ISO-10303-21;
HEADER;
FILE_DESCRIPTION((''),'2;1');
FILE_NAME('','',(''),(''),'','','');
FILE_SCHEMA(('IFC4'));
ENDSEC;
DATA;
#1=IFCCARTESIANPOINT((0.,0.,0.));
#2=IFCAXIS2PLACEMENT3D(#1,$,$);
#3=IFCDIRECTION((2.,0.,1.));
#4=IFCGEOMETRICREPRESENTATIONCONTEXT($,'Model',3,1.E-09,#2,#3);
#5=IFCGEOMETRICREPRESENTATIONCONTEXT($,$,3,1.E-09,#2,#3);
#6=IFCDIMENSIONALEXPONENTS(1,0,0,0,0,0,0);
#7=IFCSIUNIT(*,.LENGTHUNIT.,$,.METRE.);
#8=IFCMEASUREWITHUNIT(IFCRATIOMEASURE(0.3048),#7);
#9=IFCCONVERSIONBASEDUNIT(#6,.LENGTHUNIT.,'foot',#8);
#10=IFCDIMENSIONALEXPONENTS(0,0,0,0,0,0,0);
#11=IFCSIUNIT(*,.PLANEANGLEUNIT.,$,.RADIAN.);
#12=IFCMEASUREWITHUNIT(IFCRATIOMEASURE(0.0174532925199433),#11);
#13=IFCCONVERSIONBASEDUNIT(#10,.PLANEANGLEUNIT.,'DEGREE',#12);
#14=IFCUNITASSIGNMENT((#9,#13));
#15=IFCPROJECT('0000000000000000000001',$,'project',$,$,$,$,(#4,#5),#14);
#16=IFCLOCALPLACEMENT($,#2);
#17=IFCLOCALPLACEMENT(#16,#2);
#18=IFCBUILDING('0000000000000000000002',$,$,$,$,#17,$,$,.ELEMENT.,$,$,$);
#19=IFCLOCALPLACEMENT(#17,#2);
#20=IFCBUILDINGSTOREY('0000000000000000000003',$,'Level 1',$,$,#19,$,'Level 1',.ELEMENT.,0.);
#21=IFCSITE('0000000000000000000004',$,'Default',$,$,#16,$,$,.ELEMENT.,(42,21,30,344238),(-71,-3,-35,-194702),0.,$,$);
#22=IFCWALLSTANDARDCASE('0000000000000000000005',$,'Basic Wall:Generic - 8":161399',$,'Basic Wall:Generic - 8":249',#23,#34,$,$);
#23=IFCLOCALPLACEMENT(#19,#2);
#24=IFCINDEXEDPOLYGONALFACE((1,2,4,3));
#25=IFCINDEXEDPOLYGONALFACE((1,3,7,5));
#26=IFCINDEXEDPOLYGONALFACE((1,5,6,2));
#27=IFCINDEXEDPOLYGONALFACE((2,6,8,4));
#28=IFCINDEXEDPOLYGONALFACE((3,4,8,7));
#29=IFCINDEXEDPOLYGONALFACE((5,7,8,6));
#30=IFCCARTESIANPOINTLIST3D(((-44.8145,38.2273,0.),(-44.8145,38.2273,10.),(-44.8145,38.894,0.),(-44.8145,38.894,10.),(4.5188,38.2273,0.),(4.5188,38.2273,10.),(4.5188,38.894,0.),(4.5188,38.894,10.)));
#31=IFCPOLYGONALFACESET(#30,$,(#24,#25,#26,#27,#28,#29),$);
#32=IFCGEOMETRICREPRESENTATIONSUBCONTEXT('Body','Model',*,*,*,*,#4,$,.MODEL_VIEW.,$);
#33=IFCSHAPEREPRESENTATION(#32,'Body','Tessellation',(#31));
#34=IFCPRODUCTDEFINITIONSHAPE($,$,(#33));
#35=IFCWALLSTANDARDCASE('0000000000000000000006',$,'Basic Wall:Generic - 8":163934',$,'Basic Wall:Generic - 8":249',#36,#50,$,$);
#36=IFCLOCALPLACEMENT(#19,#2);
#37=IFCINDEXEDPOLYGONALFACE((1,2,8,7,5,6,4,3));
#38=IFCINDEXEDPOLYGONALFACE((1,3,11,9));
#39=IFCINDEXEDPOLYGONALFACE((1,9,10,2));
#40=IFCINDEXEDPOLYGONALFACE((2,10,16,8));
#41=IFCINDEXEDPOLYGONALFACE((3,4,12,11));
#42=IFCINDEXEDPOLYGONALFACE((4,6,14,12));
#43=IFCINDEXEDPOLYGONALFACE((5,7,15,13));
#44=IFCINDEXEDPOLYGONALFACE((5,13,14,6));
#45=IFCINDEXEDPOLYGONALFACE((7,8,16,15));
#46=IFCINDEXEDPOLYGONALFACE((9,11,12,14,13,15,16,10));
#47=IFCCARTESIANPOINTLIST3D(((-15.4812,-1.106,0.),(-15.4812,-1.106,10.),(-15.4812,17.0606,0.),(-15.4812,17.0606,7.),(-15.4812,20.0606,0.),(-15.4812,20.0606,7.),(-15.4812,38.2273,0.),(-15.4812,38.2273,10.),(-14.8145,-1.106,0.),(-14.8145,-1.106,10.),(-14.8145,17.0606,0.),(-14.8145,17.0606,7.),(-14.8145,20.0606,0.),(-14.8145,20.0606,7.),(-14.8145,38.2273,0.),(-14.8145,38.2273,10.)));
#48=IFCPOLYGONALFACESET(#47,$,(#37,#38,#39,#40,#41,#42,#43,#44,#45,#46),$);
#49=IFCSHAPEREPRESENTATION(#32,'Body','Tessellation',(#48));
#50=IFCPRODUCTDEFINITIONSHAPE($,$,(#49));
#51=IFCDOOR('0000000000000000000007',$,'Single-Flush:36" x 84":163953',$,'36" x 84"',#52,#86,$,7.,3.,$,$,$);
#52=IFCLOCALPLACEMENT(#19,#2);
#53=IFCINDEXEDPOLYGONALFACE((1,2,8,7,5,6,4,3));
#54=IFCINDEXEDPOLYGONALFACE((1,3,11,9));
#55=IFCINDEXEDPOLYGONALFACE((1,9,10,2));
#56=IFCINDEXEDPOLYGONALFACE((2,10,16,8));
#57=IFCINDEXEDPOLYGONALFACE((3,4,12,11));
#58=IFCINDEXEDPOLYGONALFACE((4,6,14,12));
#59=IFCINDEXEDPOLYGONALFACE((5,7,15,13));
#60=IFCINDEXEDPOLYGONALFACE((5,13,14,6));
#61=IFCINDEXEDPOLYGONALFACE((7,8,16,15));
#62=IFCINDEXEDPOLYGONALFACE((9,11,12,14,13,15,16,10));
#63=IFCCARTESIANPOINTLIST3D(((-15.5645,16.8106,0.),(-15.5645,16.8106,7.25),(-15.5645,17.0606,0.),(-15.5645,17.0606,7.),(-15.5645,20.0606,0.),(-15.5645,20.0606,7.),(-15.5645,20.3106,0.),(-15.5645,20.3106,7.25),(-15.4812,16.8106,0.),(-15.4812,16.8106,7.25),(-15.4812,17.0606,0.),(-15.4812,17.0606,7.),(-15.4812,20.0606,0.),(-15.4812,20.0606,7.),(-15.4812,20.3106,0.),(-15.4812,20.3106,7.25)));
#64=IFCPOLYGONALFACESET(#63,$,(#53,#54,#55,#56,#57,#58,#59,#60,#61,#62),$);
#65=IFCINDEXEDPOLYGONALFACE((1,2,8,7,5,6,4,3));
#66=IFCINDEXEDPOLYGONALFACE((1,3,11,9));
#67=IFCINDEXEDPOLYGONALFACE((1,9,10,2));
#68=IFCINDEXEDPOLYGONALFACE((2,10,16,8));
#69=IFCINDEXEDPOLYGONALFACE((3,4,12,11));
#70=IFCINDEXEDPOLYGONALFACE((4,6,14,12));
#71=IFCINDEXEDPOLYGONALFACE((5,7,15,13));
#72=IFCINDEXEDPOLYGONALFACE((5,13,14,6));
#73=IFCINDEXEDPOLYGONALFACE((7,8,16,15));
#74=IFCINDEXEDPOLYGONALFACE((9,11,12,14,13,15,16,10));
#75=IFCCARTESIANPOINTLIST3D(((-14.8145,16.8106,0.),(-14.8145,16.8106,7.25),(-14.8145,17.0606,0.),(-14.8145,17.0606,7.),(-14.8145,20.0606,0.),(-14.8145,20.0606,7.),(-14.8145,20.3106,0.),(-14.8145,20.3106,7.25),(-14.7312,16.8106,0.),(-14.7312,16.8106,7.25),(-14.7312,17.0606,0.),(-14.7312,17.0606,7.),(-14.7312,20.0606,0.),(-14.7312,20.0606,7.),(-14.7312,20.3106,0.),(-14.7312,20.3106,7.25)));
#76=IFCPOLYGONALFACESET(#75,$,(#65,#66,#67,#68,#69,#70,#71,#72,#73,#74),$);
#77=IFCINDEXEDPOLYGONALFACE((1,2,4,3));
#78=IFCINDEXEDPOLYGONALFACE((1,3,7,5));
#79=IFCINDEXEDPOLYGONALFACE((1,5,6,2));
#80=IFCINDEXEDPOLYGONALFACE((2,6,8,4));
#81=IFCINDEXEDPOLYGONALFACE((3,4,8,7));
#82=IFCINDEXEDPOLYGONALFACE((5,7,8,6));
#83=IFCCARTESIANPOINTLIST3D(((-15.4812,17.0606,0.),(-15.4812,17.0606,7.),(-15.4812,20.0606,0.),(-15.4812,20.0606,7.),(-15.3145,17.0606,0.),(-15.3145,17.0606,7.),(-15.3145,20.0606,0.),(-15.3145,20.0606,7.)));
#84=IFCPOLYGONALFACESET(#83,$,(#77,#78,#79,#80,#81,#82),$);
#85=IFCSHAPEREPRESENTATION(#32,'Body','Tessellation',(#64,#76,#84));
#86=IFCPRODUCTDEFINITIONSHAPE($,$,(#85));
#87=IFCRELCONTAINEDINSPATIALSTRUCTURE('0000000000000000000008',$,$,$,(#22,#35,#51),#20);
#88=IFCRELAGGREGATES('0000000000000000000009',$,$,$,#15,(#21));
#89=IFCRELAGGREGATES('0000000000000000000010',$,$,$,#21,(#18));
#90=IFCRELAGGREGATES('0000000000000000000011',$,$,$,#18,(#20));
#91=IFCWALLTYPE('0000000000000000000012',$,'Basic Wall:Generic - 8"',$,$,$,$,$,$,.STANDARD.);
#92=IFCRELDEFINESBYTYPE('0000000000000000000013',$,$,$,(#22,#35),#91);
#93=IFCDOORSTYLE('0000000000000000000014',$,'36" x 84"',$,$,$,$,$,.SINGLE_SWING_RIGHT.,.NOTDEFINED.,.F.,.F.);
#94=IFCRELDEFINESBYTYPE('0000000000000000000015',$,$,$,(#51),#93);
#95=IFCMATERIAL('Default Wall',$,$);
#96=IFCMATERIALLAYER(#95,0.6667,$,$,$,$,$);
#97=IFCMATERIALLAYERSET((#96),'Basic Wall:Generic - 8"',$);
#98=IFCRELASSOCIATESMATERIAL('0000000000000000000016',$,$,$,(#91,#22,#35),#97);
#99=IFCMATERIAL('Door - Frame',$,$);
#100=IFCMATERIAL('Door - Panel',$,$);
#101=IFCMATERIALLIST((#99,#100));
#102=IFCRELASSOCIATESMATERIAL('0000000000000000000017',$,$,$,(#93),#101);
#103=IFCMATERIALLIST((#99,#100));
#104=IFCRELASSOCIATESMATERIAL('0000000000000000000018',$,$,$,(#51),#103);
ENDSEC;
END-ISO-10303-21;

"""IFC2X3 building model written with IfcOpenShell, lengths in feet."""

from ifc_helpers import new_model, entity, si_unit, converted_unit, direction, frame, frame_2d, origin, place, context, subcontext, project, spatial, polyline, rectangle, outline, extrude, clip, bounded_halfspace, source, transform, mapped, material, material_list, layer, layer_set, layer_usage, type_object, type_shapes, element, fill, save


model = new_model("IFC2X3")

# Units and contexts
model_context = context("Model", 3, precision=1e-09, world=origin(), true_north=direction((2.0, 0.0, 1.0)))
context_of_model = context(None, 3, precision=1e-09, world=origin(), true_north=direction((2.0, 0.0, 1.0)))
body_context = subcontext(model_context, "Body", "Model", "MODEL_VIEW")
ifc_project = project(units=[converted_unit("LENGTHUNIT", "foot", entity("IfcRatioMeasure", 0.3048), si_unit("LENGTHUNIT", "METRE"), dimensions=[1, 0, 0, 0, 0, 0, 0]), converted_unit("PLANEANGLEUNIT", "DEGREE", entity("IfcRatioMeasure", 0.0174532925199433), si_unit("PLANEANGLEUNIT", "RADIAN"), dimensions=[0, 0, 0, 0, 0, 0, 0])], contexts=[model_context, context_of_model])

# Site, building, storey
site_placement = place(None, origin())
site = spatial("IfcSite", under=ifc_project, at=site_placement, Name="Default", CompositionType="ELEMENT", RefLatitude=(42, 21, 30, 344238), RefLongitude=(-71, -3, -35, -194702), RefElevation=0.0)
building_placement = place(site_placement, origin())
building = spatial("IfcBuilding", under=site, at=building_placement, CompositionType="ELEMENT")
storey_placement = place(building_placement, origin())
storey = spatial("IfcBuildingStorey", under=building, at=storey_placement, Name="Level 1", LongName="Level 1", CompositionType="ELEMENT", Elevation=0.0)

# Shared definitions
ifc_material_1 = material(Name="Default Wall")
ifc_layer_1 = layer(ifc_material_1, 0.6667)
ifc_layer_set_1 = layer_set([ifc_layer_1], Name="Basic Wall:Generic - 8\"")
wall_type = type_object("IfcWallType", Name="Basic Wall:Generic - 8\"", PredefinedType="STANDARD", material=ifc_layer_set_1)

# Shared definitions
ifc_material_2 = material(Name="Door - Frame")
ifc_material_3 = material(Name="Door - Panel")
ifc_material_list_1 = material_list([ifc_material_2, ifc_material_3])
door_style = type_object("IfcDoorStyle", Name="36\" x 84\"", ConstructionType="NOTDEFINED", OperationType="SINGLE_SWING_RIGHT", ParameterTakesPrecedence=False, Sizeable=False, material=ifc_material_list_1)
shared_shape_1 = source(origin(), body_context, "Body", "SweptSolid", [
    extrude(outline(polyline([(-1.75, -3.6875), (1.75, -3.6875), (1.75, 3.5625), (1.5, 3.5625), (1.5, -3.4375), (-1.5, -3.4375), (-1.5, 3.5625), (-1.75, 3.5625), (-1.75, -3.6875)])), frame((1.5, 0.6667, 3.5625), z_axis=(0.0, 1.0, 0.0), x_axis=(1.0, 0.0, 0.0)), (0.0, 0.0, 1.0), 0.0833),
    extrude(outline(polyline([(-3.6875, -1.75), (3.5625, -1.75), (3.5625, -1.5), (-3.4375, -1.5), (-3.4375, 1.5), (3.5625, 1.5), (3.5625, 1.75), (-3.6875, 1.75), (-3.6875, -1.75)])), frame((1.5, -0.0833, 3.5625), z_axis=(0.0, 1.0, 0.0), x_axis=(0.0, 0.0, -1.0)), (0.0, 0.0, 1.0), 0.0833),
    extrude(rectangle(XDim=0.1667, YDim=3.0, at=frame_2d((0.0, 0.0), x_axis=(1.0, 0.0))), frame((1.5, 0.5833, 0.0), z_axis=(0.0, 0.0, 1.0), x_axis=(0.0, 1.0, 0.0)), (0.0, 0.0, 1.0), 7.0),
])
type_shapes(door_style, [shared_shape_1])

# Wall
ifc_layer_usage_1 = layer_usage(ifc_layer_set_1, "AXIS2", "NEGATIVE", 0.3333)
wall_1_placement = place(storey_placement, frame((4.5188, 38.5606, 0.0), z_axis=(0.0, 0.0, 1.0), x_axis=(-1.0, 0.0, 0.0)))
element("IfcWallStandardCase", 1, at=wall_1_placement, inside=storey, type_object=wall_type, material=ifc_layer_usage_1, Name="Basic Wall:Generic - 8\":161399", ObjectType="Basic Wall:Generic - 8\":249", context=body_context, shape_type="Clipping", body=[
    clip(extrude(rectangle(XDim=49.3333, YDim=0.6667, at=frame_2d((24.6667, 0.0), x_axis=(-1.0, 0.0))), origin(), (0.0, 0.0, 1.0), 10.0), bounded_halfspace(frame((0.0, -0.3333, 10.0), z_axis=(0.0, 0.0, 1.0), x_axis=(-1.0, 0.0, 0.0)), False, frame((0.0, -0.3333, 10.0)), polyline([(0.0, 0.0), (49.3333, 0.0), (49.3333, 0.6667), (20.0, 0.6667), (19.3333, 0.6667), (0.0, 0.6667), (0.0, 0.0)]))),
])

# Wall, opening, door
ifc_layer_usage_2 = layer_usage(ifc_layer_set_1, "AXIS2", "NEGATIVE", 0.3333)
wall_2_placement = place(storey_placement, frame((-15.1479, 38.2273, 0.0), z_axis=(0.0, 0.0, 1.0), x_axis=(0.0, -1.0, 0.0)))
wall_2 = element("IfcWallStandardCase", 2, at=wall_2_placement, inside=storey, type_object=wall_type, material=ifc_layer_usage_2, Name="Basic Wall:Generic - 8\":163934", ObjectType="Basic Wall:Generic - 8\":249", context=body_context, shape_type="SweptSolid", body=[
    extrude(rectangle(XDim=39.3333, YDim=0.6667, at=frame_2d((19.6667, 0.0), x_axis=(-1.0, 0.0))), origin(), (0.0, 0.0, 1.0), 10.0),
])
opening_1_placement = place(wall_2_placement, frame((21.1667, 0.3333, 0.0)))
opening_1 = element("IfcOpeningElement", 3, at=opening_1_placement, cuts=wall_2, ObjectType="Opening", context=body_context, shape_type="SweptSolid", body=[
    extrude(rectangle(XDim=3.0, YDim=7.0, at=frame_2d((3.5, 1.5), x_axis=(0.0, 1.0))), frame((0.0, 0.0, 0.0), z_axis=(0.0, -1.0, 0.0), x_axis=(0.0, 0.0, 1.0)), (0.0, 0.0, 1.0), 0.6667),
])
ifc_material_list_2 = material_list([ifc_material_2, ifc_material_3])
door_1_placement = place(storey_placement, frame((-14.8145, 17.0606, 0.0), z_axis=(0.0, 0.0, 1.0), x_axis=(0.0, 1.0, 0.0)))
door_1 = element("IfcDoor", 4, at=door_1_placement, inside=storey, type_object=door_style, material=ifc_material_list_2, Name="Single-Flush:36\" x 84\":163953", ObjectType="36\" x 84\"", OverallHeight=7.0, OverallWidth=3.0, context=body_context, shape_type="MappedRepresentation", body=[
    mapped(shared_shape_1, transform((0.0, 0.0, 0.0), scale=1.0)),
])
fill(opening_1, door_1)

save(model, "model.ifc")
